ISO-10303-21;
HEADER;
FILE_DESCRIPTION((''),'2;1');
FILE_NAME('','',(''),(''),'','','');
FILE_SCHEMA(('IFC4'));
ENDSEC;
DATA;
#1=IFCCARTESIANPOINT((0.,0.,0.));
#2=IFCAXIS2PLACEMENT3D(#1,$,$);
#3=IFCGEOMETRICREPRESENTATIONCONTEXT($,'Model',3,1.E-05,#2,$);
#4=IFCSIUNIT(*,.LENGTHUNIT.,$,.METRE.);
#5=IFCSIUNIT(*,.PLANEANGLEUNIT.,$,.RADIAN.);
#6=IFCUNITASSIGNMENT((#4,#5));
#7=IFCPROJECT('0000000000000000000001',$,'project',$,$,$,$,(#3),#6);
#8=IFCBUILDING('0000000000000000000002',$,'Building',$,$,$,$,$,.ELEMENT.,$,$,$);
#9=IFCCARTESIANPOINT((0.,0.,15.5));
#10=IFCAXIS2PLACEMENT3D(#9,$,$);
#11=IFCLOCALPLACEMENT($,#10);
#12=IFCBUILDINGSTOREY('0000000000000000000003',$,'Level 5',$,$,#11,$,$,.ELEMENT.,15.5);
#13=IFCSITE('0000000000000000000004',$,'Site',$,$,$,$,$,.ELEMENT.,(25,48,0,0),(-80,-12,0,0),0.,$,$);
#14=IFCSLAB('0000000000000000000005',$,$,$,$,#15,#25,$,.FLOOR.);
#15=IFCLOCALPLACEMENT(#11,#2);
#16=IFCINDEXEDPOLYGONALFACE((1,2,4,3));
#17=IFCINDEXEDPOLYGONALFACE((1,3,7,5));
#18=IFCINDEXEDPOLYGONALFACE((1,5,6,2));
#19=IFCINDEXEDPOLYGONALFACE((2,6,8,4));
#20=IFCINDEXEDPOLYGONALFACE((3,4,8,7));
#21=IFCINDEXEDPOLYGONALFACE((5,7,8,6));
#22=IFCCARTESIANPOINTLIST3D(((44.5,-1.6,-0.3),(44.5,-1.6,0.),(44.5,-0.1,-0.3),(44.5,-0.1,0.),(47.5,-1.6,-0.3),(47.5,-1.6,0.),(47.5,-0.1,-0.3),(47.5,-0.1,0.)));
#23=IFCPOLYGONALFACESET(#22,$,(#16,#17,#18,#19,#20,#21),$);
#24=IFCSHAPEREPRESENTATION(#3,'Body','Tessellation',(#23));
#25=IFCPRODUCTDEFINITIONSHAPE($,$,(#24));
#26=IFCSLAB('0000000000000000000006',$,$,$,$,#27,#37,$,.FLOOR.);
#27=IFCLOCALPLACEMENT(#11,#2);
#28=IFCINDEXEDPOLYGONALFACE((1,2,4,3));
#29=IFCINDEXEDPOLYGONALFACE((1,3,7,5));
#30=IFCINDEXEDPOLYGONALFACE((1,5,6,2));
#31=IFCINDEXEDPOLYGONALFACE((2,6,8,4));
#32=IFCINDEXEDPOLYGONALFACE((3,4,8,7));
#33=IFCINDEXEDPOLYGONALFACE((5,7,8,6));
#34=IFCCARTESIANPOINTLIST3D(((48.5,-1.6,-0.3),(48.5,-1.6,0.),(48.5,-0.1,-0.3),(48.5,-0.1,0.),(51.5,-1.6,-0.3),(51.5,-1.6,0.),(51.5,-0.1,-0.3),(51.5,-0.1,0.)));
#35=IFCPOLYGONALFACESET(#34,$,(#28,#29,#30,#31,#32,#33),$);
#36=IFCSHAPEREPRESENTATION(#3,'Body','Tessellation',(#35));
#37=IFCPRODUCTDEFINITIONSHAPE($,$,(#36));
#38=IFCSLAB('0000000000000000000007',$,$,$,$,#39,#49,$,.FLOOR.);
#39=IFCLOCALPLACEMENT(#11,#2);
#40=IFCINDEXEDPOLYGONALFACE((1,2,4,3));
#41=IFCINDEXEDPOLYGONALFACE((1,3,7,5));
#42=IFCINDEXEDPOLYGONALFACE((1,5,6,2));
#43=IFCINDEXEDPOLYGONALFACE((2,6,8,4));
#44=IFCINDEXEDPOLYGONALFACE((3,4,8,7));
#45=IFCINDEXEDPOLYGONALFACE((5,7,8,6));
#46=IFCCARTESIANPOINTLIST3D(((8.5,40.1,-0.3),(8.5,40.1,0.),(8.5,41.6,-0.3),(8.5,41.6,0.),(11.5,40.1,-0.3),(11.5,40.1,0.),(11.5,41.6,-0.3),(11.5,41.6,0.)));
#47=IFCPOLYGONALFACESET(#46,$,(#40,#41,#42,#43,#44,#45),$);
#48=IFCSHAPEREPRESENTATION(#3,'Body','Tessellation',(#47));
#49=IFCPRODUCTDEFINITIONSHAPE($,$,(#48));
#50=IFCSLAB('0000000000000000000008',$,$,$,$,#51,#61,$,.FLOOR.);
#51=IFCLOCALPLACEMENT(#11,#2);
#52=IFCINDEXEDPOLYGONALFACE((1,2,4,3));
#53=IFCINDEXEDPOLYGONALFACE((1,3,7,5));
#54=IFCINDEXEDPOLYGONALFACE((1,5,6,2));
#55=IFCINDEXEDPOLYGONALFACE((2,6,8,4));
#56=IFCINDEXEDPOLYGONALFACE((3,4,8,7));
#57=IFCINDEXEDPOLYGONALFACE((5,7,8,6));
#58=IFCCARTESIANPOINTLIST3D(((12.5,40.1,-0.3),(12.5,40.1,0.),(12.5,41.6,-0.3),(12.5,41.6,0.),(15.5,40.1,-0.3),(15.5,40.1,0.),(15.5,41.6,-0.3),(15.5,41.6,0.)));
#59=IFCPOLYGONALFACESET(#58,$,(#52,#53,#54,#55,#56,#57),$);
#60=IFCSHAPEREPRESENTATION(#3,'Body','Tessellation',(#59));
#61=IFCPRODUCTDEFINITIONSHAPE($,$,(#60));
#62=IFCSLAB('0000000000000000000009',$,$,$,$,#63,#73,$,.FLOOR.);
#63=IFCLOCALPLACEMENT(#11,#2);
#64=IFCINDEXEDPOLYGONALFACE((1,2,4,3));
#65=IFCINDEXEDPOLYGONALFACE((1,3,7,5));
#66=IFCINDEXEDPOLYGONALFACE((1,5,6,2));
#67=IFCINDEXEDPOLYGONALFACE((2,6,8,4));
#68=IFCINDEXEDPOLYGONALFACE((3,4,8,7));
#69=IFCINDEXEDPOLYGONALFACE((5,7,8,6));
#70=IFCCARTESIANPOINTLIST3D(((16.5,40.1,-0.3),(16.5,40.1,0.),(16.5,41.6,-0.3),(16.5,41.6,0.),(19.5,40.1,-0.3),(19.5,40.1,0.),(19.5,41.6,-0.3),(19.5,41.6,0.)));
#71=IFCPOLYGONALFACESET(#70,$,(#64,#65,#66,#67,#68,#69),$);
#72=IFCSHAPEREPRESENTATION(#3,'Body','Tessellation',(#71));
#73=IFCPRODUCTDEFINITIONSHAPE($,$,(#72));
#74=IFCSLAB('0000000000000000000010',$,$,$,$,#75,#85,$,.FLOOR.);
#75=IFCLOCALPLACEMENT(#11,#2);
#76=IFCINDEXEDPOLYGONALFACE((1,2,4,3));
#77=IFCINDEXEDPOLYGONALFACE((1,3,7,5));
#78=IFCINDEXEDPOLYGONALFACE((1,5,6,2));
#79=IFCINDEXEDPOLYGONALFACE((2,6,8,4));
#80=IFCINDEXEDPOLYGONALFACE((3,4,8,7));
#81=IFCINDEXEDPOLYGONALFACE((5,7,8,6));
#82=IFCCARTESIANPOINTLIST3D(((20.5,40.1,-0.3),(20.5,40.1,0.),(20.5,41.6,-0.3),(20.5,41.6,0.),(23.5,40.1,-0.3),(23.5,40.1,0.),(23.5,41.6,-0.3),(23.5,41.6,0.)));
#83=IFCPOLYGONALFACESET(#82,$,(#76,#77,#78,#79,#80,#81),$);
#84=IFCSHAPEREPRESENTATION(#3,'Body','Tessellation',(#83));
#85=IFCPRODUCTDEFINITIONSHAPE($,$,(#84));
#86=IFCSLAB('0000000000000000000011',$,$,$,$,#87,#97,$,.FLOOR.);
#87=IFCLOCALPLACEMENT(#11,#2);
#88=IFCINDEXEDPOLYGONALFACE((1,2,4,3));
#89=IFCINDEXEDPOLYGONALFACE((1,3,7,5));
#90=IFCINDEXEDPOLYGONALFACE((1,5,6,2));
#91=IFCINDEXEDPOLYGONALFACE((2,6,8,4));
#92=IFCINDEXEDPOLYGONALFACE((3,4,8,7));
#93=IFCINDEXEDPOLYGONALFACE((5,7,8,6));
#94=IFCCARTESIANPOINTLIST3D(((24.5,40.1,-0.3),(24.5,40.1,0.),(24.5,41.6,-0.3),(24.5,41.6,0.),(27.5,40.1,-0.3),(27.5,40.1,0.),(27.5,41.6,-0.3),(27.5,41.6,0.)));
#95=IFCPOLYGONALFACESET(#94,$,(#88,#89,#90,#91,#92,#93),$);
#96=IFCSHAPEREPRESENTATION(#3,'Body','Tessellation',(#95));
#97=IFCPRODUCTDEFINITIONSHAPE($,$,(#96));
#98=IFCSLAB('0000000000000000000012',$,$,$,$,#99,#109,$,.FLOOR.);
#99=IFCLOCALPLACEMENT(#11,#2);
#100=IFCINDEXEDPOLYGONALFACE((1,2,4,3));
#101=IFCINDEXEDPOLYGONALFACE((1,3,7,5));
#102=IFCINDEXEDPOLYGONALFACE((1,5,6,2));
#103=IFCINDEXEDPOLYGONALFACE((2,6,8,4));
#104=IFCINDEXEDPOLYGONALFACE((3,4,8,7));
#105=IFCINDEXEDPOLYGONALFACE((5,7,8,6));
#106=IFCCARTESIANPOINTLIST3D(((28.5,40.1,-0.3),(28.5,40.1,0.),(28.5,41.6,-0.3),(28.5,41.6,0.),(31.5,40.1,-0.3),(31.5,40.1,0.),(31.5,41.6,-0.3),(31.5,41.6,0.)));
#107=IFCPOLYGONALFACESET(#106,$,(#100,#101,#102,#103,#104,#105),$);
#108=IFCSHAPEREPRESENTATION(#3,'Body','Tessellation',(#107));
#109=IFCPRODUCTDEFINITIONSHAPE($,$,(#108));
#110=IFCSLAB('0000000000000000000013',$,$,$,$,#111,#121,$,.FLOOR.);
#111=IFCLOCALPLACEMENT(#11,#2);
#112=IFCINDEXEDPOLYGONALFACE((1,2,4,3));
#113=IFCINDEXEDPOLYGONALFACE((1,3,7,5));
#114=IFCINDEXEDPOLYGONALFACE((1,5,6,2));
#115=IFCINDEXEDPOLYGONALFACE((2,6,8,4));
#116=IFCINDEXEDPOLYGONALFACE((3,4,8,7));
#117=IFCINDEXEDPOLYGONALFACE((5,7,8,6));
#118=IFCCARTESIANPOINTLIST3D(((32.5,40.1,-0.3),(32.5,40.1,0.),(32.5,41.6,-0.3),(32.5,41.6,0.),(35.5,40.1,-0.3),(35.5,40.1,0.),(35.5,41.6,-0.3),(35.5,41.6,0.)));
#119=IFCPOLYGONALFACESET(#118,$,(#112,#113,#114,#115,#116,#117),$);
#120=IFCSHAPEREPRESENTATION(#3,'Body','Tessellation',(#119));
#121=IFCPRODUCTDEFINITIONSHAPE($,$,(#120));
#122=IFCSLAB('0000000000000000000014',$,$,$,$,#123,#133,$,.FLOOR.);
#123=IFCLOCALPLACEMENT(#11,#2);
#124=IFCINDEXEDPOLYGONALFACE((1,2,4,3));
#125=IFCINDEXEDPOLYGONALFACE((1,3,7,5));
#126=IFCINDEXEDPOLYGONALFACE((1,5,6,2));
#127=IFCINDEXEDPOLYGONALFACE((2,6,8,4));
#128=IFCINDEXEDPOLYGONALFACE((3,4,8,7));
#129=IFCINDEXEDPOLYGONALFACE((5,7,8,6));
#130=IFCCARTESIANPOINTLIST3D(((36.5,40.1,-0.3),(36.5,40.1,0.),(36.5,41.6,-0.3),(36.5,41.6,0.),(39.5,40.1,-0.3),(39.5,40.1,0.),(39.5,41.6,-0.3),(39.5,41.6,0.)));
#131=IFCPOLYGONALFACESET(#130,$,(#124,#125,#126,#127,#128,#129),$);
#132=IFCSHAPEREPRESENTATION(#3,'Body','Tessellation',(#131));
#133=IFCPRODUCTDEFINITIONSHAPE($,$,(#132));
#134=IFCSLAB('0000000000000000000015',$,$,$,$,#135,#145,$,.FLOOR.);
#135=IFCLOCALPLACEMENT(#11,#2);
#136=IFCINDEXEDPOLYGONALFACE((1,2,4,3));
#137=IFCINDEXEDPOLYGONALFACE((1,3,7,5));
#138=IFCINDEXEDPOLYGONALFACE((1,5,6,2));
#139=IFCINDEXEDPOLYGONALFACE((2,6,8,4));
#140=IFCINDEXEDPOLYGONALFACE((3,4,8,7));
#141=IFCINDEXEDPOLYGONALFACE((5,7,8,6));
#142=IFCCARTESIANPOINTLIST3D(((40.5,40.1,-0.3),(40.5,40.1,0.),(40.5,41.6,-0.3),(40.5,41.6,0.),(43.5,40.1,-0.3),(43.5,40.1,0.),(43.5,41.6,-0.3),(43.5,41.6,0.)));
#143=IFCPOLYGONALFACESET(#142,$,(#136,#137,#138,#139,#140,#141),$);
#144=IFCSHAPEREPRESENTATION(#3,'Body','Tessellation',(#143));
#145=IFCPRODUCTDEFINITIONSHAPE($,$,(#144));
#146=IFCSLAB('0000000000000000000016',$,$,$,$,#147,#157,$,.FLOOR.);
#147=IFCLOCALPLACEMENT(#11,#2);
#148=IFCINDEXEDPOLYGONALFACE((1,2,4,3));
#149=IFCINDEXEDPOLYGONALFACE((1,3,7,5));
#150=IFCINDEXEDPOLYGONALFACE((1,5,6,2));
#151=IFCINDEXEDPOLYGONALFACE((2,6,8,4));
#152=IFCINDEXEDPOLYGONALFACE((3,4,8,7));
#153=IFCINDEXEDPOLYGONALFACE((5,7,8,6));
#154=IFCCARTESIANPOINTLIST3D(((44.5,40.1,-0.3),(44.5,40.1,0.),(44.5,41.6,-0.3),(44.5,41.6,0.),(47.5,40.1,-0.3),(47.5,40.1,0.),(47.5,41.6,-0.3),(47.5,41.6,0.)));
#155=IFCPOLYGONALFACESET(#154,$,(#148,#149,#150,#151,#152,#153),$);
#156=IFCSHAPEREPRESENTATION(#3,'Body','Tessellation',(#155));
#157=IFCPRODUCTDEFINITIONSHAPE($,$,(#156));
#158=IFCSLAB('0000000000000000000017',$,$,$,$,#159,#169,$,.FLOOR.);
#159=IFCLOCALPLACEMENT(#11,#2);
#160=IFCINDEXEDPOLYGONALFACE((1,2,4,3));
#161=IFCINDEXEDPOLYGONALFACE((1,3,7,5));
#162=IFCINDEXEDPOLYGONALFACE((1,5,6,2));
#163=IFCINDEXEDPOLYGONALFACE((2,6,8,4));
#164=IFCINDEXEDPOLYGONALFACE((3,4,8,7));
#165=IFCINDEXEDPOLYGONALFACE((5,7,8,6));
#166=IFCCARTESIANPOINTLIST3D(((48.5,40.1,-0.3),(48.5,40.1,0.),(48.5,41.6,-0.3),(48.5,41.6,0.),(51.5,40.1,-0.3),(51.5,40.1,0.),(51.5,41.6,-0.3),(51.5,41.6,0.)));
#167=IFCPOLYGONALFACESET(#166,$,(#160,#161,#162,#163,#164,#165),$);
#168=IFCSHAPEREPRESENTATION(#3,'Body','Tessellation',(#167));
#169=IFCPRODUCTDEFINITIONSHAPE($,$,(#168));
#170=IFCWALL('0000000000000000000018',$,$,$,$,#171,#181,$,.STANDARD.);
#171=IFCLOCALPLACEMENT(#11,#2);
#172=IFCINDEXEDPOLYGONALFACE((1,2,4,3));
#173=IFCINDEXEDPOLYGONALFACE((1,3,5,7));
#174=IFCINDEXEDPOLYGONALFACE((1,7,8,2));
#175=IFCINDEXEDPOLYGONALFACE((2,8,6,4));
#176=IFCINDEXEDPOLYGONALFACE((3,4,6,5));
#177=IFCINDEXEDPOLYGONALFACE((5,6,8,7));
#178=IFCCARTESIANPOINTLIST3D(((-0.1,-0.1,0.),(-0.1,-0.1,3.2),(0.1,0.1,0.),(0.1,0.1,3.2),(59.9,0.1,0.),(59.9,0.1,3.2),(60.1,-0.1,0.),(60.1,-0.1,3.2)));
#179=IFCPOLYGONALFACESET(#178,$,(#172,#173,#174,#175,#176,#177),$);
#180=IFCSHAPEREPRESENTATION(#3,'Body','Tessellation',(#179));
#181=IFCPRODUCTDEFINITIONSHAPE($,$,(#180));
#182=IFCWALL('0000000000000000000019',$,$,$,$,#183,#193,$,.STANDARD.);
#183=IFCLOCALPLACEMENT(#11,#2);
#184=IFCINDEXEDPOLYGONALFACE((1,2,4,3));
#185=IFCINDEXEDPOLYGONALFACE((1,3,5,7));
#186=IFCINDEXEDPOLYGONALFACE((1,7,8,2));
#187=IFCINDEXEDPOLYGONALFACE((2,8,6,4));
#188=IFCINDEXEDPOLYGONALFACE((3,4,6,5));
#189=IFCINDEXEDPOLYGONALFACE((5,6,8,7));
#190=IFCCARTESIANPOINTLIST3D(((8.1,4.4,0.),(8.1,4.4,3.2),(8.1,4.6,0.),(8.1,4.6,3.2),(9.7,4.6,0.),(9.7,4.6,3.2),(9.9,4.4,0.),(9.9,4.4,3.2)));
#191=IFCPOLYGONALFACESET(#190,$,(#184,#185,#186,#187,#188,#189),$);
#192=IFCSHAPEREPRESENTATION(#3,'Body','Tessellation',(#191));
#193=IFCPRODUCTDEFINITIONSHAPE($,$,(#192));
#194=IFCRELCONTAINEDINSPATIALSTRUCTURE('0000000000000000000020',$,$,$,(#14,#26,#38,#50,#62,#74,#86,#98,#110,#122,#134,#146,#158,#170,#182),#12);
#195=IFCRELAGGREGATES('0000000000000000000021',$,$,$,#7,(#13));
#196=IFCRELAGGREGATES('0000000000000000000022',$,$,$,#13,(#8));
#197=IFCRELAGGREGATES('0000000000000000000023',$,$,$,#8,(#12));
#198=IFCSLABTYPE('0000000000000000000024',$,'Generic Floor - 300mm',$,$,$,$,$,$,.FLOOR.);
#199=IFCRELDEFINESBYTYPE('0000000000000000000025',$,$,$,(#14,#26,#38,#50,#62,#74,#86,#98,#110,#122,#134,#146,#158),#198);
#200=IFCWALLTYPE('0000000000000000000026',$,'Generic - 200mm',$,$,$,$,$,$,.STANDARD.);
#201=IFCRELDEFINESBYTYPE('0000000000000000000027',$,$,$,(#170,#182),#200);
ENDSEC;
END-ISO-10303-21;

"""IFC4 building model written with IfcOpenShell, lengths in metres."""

from ifc_helpers import new_model, si_unit, frame, origin, place, context, project, spatial, polyline, outline, extrude, type_object, element, save


model = new_model("IFC4")

# Units and contexts
model_context = context("Model", 3, precision=1e-05, world=origin())
ifc_project = project(units=[si_unit("LENGTHUNIT", "METRE"), si_unit("PLANEANGLEUNIT", "RADIAN")], contexts=[model_context])

# Site, building, storey
site = spatial("IfcSite", under=ifc_project, Name="Site", CompositionType="ELEMENT", RefLatitude=(25, 48, 0, 0), RefLongitude=(-80, -12, 0, 0), RefElevation=0.0)
building = spatial("IfcBuilding", under=site, Name="Building", CompositionType="ELEMENT")
storey_placement = place(None, frame((0.0, 0.0, 15.5)))
storey = spatial("IfcBuildingStorey", under=building, at=storey_placement, Name="Level 5", CompositionType="ELEMENT", Elevation=15.5)

# Shared definitions
slab_type = type_object("IfcSlabType", Name="Generic Floor - 300mm", PredefinedType="FLOOR")

# Slabs
slab_1_placement = place(None, frame((0.0, 0.0, 15.5)))
element("IfcSlab", 1, at=slab_1_placement, inside=storey, type_object=slab_type, PredefinedType="FLOOR", context=model_context, shape_type="SweptSolid", body=[
    extrude(outline(polyline([(44.5, -0.1), (44.5, -1.6), (47.5, -1.6), (47.5, -0.1), (44.5, -0.1)])), origin(), (0.0, 0.0, -1.0), 0.3),
])
slab_2_placement = place(None, frame((0.0, 0.0, 15.5)))
element("IfcSlab", 2, at=slab_2_placement, inside=storey, type_object=slab_type, PredefinedType="FLOOR", context=model_context, shape_type="SweptSolid", body=[
    extrude(outline(polyline([(51.5, -0.1), (48.5, -0.1), (48.5, -1.6), (51.5, -1.6), (51.5, -0.1)])), origin(), (0.0, 0.0, -1.0), 0.3),
])
slab_3_placement = place(None, frame((0.0, 0.0, 15.5)))
element("IfcSlab", 3, at=slab_3_placement, inside=storey, type_object=slab_type, PredefinedType="FLOOR", context=model_context, shape_type="SweptSolid", body=[
    extrude(outline(polyline([(8.5, 40.1), (11.5, 40.1), (11.5, 41.6), (8.5, 41.6), (8.5, 40.1)])), origin(), (0.0, 0.0, -1.0), 0.3),
])
slab_4_placement = place(None, frame((0.0, 0.0, 15.5)))
element("IfcSlab", 4, at=slab_4_placement, inside=storey, type_object=slab_type, PredefinedType="FLOOR", context=model_context, shape_type="SweptSolid", body=[
    extrude(outline(polyline([(15.5, 40.1), (15.5, 41.6), (12.5, 41.6), (12.5, 40.1), (15.5, 40.1)])), origin(), (0.0, 0.0, -1.0), 0.3),
])
slab_5_placement = place(None, frame((0.0, 0.0, 15.5)))
element("IfcSlab", 5, at=slab_5_placement, inside=storey, type_object=slab_type, PredefinedType="FLOOR", context=model_context, shape_type="SweptSolid", body=[
    extrude(outline(polyline([(16.5, 40.1), (19.5, 40.1), (19.5, 41.6), (16.5, 41.6), (16.5, 40.1)])), origin(), (0.0, 0.0, -1.0), 0.3),
])
slab_6_placement = place(None, frame((0.0, 0.0, 15.5)))
element("IfcSlab", 6, at=slab_6_placement, inside=storey, type_object=slab_type, PredefinedType="FLOOR", context=model_context, shape_type="SweptSolid", body=[
    extrude(outline(polyline([(23.5, 40.1), (23.5, 41.6), (20.5, 41.6), (20.5, 40.1), (23.5, 40.1)])), origin(), (0.0, 0.0, -1.0), 0.3),
])
slab_7_placement = place(None, frame((0.0, 0.0, 15.5)))
element("IfcSlab", 7, at=slab_7_placement, inside=storey, type_object=slab_type, PredefinedType="FLOOR", context=model_context, shape_type="SweptSolid", body=[
    extrude(outline(polyline([(24.5, 40.1), (27.5, 40.1), (27.5, 41.6), (24.5, 41.6), (24.5, 40.1)])), origin(), (0.0, 0.0, -1.0), 0.3),
])
slab_8_placement = place(None, frame((0.0, 0.0, 15.5)))
element("IfcSlab", 8, at=slab_8_placement, inside=storey, type_object=slab_type, PredefinedType="FLOOR", context=model_context, shape_type="SweptSolid", body=[
    extrude(outline(polyline([(31.5, 40.1), (31.5, 41.6), (28.5, 41.6), (28.5, 40.1), (31.5, 40.1)])), origin(), (0.0, 0.0, -1.0), 0.3),
])
slab_9_placement = place(None, frame((0.0, 0.0, 15.5)))
element("IfcSlab", 9, at=slab_9_placement, inside=storey, type_object=slab_type, PredefinedType="FLOOR", context=model_context, shape_type="SweptSolid", body=[
    extrude(outline(polyline([(32.5, 40.1), (35.5, 40.1), (35.5, 41.6), (32.5, 41.6), (32.5, 40.1)])), origin(), (0.0, 0.0, -1.0), 0.3),
])
slab_10_placement = place(None, frame((0.0, 0.0, 15.5)))
element("IfcSlab", 10, at=slab_10_placement, inside=storey, type_object=slab_type, PredefinedType="FLOOR", context=model_context, shape_type="SweptSolid", body=[
    extrude(outline(polyline([(39.5, 40.1), (39.5, 41.6), (36.5, 41.6), (36.5, 40.1), (39.5, 40.1)])), origin(), (0.0, 0.0, -1.0), 0.3),
])
slab_11_placement = place(None, frame((0.0, 0.0, 15.5)))
element("IfcSlab", 11, at=slab_11_placement, inside=storey, type_object=slab_type, PredefinedType="FLOOR", context=model_context, shape_type="SweptSolid", body=[
    extrude(outline(polyline([(40.5, 40.1), (43.5, 40.1), (43.5, 41.6), (40.5, 41.6), (40.5, 40.1)])), origin(), (0.0, 0.0, -1.0), 0.3),
])
slab_12_placement = place(None, frame((0.0, 0.0, 15.5)))
element("IfcSlab", 12, at=slab_12_placement, inside=storey, type_object=slab_type, PredefinedType="FLOOR", context=model_context, shape_type="SweptSolid", body=[
    extrude(outline(polyline([(47.5, 40.1), (47.5, 41.6), (44.5, 41.6), (44.5, 40.1), (47.5, 40.1)])), origin(), (0.0, 0.0, -1.0), 0.3),
])
slab_13_placement = place(None, frame((0.0, 0.0, 15.5)))
element("IfcSlab", 13, at=slab_13_placement, inside=storey, type_object=slab_type, PredefinedType="FLOOR", context=model_context, shape_type="SweptSolid", body=[
    extrude(outline(polyline([(48.5, 40.1), (51.5, 40.1), (51.5, 41.6), (48.5, 41.6), (48.5, 40.1)])), origin(), (0.0, 0.0, -1.0), 0.3),
])

# Walls
wall_type = type_object("IfcWallType", Name="Generic - 200mm", PredefinedType="STANDARD")
wall_1_placement = place(None, frame((0.0, 0.0, 15.5), z_axis=(0.0, 0.0, 1.0), x_axis=(1.0, 0.0, 0.0)))
element("IfcWall", 14, at=wall_1_placement, inside=storey, type_object=wall_type, PredefinedType="STANDARD", context=model_context, shape_type="SweptSolid", body=[
    extrude(outline(polyline([(-0.1, -0.1), (60.1, -0.1), (59.9, 0.1), (0.1, 0.1), (-0.1, -0.1)])), origin(), (0.0, 0.0, 1.0), 3.2),
])
wall_2_placement = place(None, frame((9.8, 4.5, 15.5), z_axis=(0.0, 0.0, 1.0), x_axis=(-1.0, 0.0, 0.0)))
element("IfcWall", 15, at=wall_2_placement, inside=storey, type_object=wall_type, PredefinedType="STANDARD", context=model_context, shape_type="SweptSolid", body=[
    extrude(outline(polyline([(0.1, -0.1), (1.7, -0.1), (1.7, 0.1), (-0.1, 0.1), (0.1, -0.1)])), origin(), (0.0, 0.0, 1.0), 3.2),
])

save(model, "model.ifc")
